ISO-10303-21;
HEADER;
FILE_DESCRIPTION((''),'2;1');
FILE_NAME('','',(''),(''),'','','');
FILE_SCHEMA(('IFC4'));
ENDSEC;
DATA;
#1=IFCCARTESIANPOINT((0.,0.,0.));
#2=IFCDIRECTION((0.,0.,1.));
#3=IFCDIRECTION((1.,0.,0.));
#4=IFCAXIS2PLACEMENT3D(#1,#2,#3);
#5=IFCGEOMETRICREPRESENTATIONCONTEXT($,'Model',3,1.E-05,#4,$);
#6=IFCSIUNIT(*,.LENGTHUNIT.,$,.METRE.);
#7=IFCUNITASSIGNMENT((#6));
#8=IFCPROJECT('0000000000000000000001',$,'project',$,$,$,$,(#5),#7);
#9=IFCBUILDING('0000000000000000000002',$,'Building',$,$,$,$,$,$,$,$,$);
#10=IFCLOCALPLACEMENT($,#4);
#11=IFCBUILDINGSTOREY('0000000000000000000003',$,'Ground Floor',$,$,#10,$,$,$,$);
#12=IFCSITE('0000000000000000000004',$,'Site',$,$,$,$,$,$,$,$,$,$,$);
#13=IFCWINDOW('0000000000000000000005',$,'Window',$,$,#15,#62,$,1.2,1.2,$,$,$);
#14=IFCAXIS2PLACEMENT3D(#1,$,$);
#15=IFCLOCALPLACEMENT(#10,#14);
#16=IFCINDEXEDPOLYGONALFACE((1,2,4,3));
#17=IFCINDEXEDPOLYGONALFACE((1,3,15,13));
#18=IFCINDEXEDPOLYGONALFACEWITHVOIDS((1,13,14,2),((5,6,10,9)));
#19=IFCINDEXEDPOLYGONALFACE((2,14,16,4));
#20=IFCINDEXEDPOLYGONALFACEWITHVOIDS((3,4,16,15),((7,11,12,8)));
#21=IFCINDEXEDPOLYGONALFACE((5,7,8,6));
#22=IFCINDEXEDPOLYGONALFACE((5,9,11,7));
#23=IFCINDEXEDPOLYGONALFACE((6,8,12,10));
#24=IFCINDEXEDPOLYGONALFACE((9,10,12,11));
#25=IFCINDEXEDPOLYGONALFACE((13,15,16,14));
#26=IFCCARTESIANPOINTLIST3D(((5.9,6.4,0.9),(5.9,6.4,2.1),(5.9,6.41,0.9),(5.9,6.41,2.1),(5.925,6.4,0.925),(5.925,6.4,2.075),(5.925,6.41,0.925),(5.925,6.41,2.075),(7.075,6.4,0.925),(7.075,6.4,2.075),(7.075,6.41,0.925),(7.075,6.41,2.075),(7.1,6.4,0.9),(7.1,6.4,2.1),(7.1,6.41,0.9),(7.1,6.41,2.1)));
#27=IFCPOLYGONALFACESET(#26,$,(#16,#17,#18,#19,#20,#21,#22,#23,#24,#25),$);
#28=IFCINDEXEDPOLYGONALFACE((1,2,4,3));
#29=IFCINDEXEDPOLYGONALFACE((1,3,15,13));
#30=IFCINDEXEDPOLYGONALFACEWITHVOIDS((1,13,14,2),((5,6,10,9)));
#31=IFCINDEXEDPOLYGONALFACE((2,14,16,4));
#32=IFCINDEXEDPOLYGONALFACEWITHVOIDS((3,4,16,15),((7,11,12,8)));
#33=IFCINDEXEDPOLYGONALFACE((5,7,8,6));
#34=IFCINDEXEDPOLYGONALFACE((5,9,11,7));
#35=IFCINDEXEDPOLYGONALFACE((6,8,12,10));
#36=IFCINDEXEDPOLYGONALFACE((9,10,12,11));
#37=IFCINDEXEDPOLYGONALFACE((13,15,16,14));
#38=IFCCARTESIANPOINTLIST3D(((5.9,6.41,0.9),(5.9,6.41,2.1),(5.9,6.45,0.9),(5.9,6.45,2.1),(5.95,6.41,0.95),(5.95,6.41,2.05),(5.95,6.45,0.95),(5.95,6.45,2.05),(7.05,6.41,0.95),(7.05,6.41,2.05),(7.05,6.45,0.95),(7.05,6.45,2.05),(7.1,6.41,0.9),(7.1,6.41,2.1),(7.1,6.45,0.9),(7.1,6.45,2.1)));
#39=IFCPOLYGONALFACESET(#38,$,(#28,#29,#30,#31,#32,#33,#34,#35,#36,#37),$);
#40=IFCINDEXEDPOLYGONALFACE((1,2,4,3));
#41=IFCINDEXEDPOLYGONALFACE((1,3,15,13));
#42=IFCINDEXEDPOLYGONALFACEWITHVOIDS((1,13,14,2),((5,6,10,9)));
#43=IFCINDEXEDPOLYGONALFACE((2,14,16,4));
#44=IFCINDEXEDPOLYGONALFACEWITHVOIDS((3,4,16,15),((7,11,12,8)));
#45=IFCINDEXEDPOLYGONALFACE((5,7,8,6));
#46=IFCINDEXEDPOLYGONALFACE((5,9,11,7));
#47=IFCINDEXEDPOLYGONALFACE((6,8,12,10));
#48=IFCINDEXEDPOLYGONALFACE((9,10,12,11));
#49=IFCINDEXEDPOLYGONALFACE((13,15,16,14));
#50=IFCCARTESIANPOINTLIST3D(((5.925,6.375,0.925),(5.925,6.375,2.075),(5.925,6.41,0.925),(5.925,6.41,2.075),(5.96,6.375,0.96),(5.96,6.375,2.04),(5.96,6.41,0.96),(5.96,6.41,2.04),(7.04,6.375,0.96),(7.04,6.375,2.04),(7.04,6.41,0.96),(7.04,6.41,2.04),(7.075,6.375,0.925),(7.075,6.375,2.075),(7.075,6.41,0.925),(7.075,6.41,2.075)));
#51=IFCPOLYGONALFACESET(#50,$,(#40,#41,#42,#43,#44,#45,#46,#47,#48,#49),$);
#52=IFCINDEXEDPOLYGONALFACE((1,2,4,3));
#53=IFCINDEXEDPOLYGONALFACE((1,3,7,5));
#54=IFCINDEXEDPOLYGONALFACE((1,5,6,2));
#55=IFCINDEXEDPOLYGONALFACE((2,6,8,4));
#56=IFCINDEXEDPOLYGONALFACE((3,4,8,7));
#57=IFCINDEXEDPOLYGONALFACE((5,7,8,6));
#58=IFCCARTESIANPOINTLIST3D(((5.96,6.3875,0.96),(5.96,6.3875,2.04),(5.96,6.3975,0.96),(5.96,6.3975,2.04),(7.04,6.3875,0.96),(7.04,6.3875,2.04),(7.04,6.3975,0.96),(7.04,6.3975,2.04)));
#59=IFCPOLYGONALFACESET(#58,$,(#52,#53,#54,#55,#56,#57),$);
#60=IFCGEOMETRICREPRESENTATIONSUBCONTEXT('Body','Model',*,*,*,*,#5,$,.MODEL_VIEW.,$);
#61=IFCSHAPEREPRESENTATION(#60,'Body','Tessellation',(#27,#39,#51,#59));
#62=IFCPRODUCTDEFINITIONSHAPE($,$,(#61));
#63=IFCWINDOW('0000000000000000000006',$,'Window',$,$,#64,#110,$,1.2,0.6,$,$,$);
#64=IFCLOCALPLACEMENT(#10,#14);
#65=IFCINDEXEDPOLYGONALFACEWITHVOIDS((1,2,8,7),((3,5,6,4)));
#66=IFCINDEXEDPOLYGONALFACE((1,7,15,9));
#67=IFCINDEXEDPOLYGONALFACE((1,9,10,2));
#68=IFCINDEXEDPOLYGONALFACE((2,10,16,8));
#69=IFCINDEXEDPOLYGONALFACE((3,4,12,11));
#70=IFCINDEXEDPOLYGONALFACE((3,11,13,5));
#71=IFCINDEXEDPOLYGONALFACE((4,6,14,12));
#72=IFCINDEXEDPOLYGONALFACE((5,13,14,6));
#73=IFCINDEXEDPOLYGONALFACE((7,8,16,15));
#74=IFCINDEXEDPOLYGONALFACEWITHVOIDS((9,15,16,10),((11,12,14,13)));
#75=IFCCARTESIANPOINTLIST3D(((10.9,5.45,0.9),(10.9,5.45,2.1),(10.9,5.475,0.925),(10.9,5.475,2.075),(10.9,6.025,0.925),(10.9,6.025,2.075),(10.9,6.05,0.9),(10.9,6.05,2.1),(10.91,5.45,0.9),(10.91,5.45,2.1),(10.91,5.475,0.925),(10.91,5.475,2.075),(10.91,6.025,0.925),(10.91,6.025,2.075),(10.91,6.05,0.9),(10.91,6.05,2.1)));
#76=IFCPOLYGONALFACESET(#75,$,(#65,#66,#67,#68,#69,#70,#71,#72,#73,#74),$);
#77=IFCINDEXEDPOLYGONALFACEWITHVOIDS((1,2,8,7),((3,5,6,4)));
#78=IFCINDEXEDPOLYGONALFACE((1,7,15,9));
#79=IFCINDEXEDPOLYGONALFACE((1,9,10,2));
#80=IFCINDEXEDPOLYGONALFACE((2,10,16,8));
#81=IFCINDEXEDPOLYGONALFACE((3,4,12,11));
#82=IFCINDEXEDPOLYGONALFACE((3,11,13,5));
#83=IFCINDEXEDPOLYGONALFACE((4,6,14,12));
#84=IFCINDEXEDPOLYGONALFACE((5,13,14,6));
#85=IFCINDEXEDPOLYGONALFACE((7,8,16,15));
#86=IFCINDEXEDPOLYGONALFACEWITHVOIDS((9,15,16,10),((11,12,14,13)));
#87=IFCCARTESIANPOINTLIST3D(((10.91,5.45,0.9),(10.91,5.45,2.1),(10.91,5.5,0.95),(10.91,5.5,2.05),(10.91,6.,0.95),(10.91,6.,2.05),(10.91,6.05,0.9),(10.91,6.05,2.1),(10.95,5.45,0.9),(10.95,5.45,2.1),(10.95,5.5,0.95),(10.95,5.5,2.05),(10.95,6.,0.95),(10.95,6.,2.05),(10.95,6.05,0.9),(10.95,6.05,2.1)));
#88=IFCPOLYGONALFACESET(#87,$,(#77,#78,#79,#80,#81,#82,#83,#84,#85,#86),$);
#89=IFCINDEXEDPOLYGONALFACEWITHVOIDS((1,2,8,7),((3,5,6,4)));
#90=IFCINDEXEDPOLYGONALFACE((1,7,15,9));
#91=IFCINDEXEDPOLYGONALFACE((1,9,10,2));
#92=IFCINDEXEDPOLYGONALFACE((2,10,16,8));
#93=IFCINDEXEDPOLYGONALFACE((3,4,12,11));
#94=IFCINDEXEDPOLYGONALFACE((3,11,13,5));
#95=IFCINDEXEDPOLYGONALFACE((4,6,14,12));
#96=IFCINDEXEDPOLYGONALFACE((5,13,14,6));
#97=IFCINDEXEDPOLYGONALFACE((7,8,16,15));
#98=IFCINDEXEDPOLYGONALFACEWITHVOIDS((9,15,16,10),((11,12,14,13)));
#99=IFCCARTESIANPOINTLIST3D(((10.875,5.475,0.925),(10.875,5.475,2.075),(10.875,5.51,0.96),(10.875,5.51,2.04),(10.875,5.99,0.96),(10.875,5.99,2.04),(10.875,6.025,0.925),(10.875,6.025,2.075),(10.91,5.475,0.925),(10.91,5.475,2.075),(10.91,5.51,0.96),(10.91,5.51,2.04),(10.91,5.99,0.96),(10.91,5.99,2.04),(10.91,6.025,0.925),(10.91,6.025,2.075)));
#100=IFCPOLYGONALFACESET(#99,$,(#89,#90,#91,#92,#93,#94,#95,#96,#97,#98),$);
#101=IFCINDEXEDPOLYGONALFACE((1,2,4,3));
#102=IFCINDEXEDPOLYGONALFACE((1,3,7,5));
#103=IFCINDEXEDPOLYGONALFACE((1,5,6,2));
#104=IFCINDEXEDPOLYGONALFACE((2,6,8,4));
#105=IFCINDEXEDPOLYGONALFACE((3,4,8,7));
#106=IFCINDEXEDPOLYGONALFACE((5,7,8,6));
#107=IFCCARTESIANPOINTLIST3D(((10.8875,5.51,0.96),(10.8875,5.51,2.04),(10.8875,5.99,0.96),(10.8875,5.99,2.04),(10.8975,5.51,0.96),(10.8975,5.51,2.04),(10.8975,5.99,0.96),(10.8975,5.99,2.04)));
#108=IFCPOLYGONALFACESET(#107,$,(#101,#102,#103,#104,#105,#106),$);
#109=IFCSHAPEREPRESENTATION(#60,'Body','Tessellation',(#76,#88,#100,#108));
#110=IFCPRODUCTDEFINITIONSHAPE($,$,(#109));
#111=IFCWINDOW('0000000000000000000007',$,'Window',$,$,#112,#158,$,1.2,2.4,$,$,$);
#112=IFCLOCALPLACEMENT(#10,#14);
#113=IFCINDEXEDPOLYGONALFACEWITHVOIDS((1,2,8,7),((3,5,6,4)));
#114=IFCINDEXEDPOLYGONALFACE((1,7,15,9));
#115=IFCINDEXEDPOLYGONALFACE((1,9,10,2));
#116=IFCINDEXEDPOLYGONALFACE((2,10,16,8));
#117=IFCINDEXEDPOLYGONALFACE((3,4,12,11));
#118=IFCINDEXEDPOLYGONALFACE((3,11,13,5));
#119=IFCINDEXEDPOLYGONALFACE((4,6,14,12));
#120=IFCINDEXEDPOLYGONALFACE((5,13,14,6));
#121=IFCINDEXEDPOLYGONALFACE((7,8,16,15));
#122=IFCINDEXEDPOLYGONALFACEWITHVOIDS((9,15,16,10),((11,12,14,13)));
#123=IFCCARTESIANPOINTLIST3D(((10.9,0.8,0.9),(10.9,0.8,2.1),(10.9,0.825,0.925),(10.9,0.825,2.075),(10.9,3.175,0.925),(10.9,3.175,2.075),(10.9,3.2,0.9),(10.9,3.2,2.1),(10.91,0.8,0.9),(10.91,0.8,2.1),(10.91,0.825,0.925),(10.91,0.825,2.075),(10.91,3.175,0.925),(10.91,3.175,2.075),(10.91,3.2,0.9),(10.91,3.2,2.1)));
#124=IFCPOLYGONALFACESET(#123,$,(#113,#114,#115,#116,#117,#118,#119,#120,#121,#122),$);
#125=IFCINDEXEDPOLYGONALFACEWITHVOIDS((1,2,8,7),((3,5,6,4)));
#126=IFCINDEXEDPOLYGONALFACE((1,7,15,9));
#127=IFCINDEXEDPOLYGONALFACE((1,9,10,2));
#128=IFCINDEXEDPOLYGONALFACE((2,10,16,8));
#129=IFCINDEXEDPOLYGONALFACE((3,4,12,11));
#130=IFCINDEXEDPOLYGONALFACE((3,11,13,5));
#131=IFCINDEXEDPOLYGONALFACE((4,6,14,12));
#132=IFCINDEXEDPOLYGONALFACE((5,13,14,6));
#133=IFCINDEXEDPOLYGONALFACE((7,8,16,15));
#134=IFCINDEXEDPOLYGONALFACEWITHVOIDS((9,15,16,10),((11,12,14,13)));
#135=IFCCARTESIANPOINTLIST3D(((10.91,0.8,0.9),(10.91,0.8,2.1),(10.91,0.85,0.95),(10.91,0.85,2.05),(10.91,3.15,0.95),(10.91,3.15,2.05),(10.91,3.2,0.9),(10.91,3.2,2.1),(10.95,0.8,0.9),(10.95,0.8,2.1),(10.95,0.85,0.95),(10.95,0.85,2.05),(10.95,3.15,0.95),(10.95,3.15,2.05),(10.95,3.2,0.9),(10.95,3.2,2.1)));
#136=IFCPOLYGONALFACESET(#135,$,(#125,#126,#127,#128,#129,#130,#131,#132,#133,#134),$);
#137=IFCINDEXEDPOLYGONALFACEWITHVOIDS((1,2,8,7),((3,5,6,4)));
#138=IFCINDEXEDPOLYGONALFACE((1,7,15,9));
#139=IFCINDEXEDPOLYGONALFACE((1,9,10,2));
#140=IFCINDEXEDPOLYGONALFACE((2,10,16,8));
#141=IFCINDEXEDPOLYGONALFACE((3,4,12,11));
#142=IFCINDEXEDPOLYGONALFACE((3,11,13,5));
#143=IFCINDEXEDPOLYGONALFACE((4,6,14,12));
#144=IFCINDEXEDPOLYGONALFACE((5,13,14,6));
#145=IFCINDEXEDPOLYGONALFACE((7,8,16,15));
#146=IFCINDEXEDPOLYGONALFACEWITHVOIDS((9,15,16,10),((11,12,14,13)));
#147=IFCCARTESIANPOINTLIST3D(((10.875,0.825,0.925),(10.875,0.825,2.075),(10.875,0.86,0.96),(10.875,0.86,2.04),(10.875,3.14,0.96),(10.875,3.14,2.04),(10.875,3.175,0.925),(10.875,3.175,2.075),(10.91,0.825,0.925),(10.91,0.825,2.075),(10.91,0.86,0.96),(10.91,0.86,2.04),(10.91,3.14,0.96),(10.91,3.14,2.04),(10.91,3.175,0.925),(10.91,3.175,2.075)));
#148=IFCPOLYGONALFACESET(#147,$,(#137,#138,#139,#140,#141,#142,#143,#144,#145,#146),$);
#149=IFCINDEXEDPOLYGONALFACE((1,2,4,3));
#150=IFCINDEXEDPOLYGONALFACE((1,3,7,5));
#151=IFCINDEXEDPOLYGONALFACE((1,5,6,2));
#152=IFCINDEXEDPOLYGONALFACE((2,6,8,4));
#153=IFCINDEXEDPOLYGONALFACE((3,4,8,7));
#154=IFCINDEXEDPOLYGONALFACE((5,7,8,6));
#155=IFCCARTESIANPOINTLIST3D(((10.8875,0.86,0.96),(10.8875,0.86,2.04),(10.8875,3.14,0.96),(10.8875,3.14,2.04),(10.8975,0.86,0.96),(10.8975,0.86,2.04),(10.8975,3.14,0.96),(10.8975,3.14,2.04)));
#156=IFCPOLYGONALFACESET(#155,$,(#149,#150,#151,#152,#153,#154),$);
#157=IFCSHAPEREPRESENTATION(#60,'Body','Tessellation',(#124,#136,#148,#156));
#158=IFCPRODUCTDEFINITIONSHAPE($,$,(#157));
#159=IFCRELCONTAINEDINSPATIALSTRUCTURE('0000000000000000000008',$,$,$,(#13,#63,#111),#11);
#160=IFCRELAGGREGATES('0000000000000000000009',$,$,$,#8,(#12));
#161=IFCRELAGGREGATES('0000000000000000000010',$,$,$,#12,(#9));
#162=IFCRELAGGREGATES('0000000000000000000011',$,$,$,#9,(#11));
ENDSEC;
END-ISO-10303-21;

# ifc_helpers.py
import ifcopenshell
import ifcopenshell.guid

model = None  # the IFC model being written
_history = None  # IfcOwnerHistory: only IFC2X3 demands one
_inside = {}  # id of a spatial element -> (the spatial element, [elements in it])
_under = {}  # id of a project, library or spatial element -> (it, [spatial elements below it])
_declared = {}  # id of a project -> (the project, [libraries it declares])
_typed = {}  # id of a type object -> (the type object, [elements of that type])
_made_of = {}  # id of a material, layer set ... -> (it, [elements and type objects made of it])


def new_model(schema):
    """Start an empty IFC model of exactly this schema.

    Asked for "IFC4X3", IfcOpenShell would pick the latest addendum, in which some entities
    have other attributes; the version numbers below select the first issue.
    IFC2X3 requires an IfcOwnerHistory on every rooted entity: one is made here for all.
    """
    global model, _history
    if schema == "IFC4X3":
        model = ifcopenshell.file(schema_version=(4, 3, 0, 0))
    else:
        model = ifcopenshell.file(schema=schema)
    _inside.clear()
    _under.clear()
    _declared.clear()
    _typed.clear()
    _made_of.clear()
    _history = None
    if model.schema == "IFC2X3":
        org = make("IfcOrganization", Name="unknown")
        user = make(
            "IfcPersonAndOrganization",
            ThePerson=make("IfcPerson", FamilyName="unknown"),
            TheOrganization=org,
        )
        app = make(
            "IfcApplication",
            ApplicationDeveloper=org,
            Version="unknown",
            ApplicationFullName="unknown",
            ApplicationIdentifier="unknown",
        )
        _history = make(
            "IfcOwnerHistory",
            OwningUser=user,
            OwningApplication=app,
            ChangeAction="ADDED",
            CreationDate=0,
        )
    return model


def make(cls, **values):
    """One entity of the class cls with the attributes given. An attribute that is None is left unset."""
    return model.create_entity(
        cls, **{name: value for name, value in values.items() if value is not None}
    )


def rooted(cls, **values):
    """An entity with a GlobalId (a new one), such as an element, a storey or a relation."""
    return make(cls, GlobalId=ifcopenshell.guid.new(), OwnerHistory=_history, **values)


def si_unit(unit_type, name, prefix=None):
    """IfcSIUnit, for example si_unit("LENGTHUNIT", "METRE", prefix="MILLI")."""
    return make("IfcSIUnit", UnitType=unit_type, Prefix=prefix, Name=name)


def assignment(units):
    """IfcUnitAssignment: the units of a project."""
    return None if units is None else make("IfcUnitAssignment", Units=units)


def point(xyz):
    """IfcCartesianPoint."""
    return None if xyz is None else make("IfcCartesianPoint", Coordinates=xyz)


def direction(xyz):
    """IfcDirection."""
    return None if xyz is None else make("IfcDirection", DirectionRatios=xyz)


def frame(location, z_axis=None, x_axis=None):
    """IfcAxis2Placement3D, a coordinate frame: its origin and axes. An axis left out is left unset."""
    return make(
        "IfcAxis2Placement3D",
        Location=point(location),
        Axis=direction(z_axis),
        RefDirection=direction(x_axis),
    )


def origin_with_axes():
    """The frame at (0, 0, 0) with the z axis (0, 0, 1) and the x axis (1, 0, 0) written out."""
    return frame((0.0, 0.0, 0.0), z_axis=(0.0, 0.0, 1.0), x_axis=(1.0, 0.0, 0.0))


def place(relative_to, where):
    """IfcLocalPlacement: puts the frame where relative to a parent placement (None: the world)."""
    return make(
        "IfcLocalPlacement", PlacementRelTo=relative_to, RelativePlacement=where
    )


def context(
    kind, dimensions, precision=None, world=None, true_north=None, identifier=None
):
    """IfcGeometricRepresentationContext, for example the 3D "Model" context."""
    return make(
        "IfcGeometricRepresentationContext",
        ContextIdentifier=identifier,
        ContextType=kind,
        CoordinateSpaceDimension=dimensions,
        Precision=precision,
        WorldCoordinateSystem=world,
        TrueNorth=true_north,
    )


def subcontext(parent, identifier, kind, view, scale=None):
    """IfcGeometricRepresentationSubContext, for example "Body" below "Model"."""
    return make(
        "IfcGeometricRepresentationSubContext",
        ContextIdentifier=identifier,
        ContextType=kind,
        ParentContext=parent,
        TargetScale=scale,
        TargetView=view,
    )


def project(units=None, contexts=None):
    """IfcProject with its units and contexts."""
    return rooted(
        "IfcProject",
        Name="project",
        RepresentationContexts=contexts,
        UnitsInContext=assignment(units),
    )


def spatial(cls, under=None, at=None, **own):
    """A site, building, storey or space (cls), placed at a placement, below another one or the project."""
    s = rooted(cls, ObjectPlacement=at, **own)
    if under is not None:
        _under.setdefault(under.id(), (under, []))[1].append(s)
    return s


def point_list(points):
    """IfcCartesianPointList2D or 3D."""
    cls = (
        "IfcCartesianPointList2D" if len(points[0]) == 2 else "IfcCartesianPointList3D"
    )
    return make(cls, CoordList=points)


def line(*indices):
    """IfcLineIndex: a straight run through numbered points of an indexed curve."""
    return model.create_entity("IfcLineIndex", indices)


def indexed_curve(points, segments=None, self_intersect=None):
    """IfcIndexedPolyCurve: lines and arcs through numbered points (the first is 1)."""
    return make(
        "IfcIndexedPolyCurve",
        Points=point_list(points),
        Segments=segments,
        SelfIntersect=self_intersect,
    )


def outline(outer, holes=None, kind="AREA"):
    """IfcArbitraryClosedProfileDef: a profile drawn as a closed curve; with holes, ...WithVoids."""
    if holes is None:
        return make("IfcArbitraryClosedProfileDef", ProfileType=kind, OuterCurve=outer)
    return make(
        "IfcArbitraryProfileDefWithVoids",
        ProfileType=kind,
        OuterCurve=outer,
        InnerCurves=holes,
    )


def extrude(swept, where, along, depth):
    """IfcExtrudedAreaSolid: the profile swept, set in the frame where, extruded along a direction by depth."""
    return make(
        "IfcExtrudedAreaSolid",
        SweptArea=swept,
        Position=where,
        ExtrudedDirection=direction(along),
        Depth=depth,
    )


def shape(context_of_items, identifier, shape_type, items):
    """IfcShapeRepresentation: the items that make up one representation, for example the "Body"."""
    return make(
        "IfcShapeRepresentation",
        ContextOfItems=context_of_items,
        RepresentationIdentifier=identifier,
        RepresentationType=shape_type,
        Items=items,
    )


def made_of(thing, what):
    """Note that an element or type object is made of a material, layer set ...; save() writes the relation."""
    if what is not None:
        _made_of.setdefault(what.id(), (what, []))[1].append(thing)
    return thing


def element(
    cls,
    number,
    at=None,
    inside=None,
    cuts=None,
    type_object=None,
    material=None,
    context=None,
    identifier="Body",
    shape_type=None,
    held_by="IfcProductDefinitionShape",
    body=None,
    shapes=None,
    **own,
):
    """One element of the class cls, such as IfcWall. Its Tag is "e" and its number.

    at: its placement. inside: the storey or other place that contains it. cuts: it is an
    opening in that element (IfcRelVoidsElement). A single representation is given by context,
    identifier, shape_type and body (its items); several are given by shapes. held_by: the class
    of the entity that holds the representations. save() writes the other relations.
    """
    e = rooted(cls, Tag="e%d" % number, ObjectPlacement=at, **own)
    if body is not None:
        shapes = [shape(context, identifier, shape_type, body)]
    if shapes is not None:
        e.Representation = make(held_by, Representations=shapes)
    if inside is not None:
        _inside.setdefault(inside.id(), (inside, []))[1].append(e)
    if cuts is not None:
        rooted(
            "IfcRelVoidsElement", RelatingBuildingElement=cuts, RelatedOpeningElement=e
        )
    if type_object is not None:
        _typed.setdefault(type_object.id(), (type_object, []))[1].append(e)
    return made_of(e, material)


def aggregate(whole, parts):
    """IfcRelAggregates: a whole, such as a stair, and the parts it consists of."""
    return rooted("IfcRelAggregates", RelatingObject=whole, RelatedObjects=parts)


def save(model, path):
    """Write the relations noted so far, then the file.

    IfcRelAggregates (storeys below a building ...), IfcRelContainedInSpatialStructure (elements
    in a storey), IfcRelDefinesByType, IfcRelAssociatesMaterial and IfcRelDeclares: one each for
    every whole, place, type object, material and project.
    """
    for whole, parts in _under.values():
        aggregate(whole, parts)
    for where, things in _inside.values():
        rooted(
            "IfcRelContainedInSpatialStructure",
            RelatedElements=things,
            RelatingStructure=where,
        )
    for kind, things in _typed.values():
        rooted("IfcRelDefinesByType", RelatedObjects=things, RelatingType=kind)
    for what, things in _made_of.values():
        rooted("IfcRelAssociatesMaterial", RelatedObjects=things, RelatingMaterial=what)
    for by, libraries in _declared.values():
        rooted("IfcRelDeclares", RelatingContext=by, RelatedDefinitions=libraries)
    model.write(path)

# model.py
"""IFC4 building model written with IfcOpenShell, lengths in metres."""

from ifc_helpers import new_model, si_unit, frame, origin_with_axes, place, context, subcontext, project, spatial, line, indexed_curve, outline, extrude, element, save


model = new_model("IFC4")

# Units and contexts
model_context = context("Model", 3, precision=1e-05, world=origin_with_axes())
body_context = subcontext(model_context, "Body", "Model", "MODEL_VIEW")
ifc_project = project(units=[si_unit("LENGTHUNIT", "METRE")], contexts=[model_context])

# Site, building, storey
site = spatial("IfcSite", under=ifc_project, Name="Site")
building = spatial("IfcBuilding", under=site, Name="Building")
storey_placement = place(None, origin_with_axes())
storey = spatial("IfcBuildingStorey", under=building, at=storey_placement, Name="Ground Floor")

# Windows
window_1_placement = place(storey_placement, frame((7.1, 6.5, 0.9), z_axis=(0.0, 0.0, 1.0), x_axis=(-1.0, 0.0, 0.0)))
element("IfcWindow", 1, at=window_1_placement, inside=storey, Name="Window", OverallHeight=1.2, OverallWidth=1.2, context=body_context, shape_type="SweptSolid", body=[
    extrude(outline(indexed_curve([(0.0, 0.0), (1.2, 0.0), (1.2, 1.2), (0.0, 1.2)], segments=[line(1, 2, 3, 4, 1)]), holes=[indexed_curve([(0.025, 0.025), (1.175, 0.025), (1.175, 1.175), (0.025, 1.175)], segments=[line(1, 2, 3, 4, 1)])]), frame((0.0, 0.09, 0.0), z_axis=(0.0, -1.0, 0.0), x_axis=(1.0, 0.0, 0.0)), (0.0, 0.0, -1.0), 0.01),
    extrude(outline(indexed_curve([(0.0, 0.0), (1.2, 0.0), (1.2, 1.2), (0.0, 1.2)], segments=[line(1, 2, 3, 4, 1)]), holes=[indexed_curve([(0.05, 0.05), (1.15, 0.05), (1.15, 1.15), (0.05, 1.15)], segments=[line(1, 2, 3, 4, 1)])]), frame((0.0, 0.05, 0.0), z_axis=(0.0, -1.0, 0.0), x_axis=(1.0, 0.0, 0.0)), (0.0, 0.0, -1.0), 0.04),
    extrude(outline(indexed_curve([(0.0, 0.0), (1.15, 0.0), (1.15, 1.15), (0.0, 1.15)], segments=[line(1, 2, 3, 4, 1)]), holes=[indexed_curve([(0.035, 0.035), (1.115, 0.035), (1.115, 1.115), (0.035, 1.115)], segments=[line(1, 2, 3, 4, 1)])]), frame((0.025, 0.09, 0.025), z_axis=(0.0, -1.0, 0.0), x_axis=(1.0, 0.0, 0.0)), (0.0, 0.0, -1.0), 0.035),
    extrude(outline(indexed_curve([(0.035, 0.035), (1.115, 0.035), (1.115, 1.115), (0.035, 1.115)], segments=[line(1, 2, 3, 4, 1)])), frame((0.025, 0.1025, 0.025), z_axis=(0.0, -1.0, 0.0), x_axis=(1.0, 0.0, 0.0)), (0.0, 0.0, -1.0), 0.01),
])
window_2_placement = place(storey_placement, frame((11.0, 5.45, 0.9), z_axis=(0.0, 0.0, 1.0), x_axis=(0.0, 1.0, 0.0)))
element("IfcWindow", 2, at=window_2_placement, inside=storey, Name="Window", OverallHeight=1.2, OverallWidth=0.6, context=body_context, shape_type="SweptSolid", body=[
    extrude(outline(indexed_curve([(0.0, 0.0), (0.6, 0.0), (0.6, 1.2), (0.0, 1.2)], segments=[line(1, 2, 3, 4, 1)]), holes=[indexed_curve([(0.025, 0.025), (0.575, 0.025), (0.575, 1.175), (0.025, 1.175)], segments=[line(1, 2, 3, 4, 1)])]), frame((0.0, 0.09, 0.0), z_axis=(0.0, -1.0, 0.0), x_axis=(1.0, 0.0, 0.0)), (0.0, 0.0, -1.0), 0.01),
    extrude(outline(indexed_curve([(0.0, 0.0), (0.6, 0.0), (0.6, 1.2), (0.0, 1.2)], segments=[line(1, 2, 3, 4, 1)]), holes=[indexed_curve([(0.05, 0.05), (0.55, 0.05), (0.55, 1.15), (0.05, 1.15)], segments=[line(1, 2, 3, 4, 1)])]), frame((0.0, 0.05, 0.0), z_axis=(0.0, -1.0, 0.0), x_axis=(1.0, 0.0, 0.0)), (0.0, 0.0, -1.0), 0.04),
    extrude(outline(indexed_curve([(0.0, 0.0), (0.55, 0.0), (0.55, 1.15), (0.0, 1.15)], segments=[line(1, 2, 3, 4, 1)]), holes=[indexed_curve([(0.035, 0.035), (0.515, 0.035), (0.515, 1.115), (0.035, 1.115)], segments=[line(1, 2, 3, 4, 1)])]), frame((0.025, 0.09, 0.025), z_axis=(0.0, -1.0, 0.0), x_axis=(1.0, 0.0, 0.0)), (0.0, 0.0, -1.0), 0.035),
    extrude(outline(indexed_curve([(0.035, 0.035), (0.515, 0.035), (0.515, 1.115), (0.035, 1.115)], segments=[line(1, 2, 3, 4, 1)])), frame((0.025, 0.1025, 0.025), z_axis=(0.0, -1.0, 0.0), x_axis=(1.0, 0.0, 0.0)), (0.0, 0.0, -1.0), 0.01),
])
window_3_placement = place(storey_placement, frame((11.0, 0.8, 0.9), z_axis=(0.0, 0.0, 1.0), x_axis=(0.0, 1.0, 0.0)))
element("IfcWindow", 3, at=window_3_placement, inside=storey, Name="Window", OverallHeight=1.2, OverallWidth=2.4, context=body_context, shape_type="SweptSolid", body=[
    extrude(outline(indexed_curve([(0.0, 0.0), (2.4, 0.0), (2.4, 1.2), (0.0, 1.2)], segments=[line(1, 2, 3, 4, 1)]), holes=[indexed_curve([(0.025, 0.025), (2.375, 0.025), (2.375, 1.175), (0.025, 1.175)], segments=[line(1, 2, 3, 4, 1)])]), frame((0.0, 0.09, 0.0), z_axis=(0.0, -1.0, 0.0), x_axis=(1.0, 0.0, 0.0)), (0.0, 0.0, -1.0), 0.01),
    extrude(outline(indexed_curve([(0.0, 0.0), (2.4, 0.0), (2.4, 1.2), (0.0, 1.2)], segments=[line(1, 2, 3, 4, 1)]), holes=[indexed_curve([(0.05, 0.05), (2.35, 0.05), (2.35, 1.15), (0.05, 1.15)], segments=[line(1, 2, 3, 4, 1)])]), frame((0.0, 0.05, 0.0), z_axis=(0.0, -1.0, 0.0), x_axis=(1.0, 0.0, 0.0)), (0.0, 0.0, -1.0), 0.04),
    extrude(outline(indexed_curve([(0.0, 0.0), (2.35, 0.0), (2.35, 1.15), (0.0, 1.15)], segments=[line(1, 2, 3, 4, 1)]), holes=[indexed_curve([(0.035, 0.035), (2.315, 0.035), (2.315, 1.115), (0.035, 1.115)], segments=[line(1, 2, 3, 4, 1)])]), frame((0.025, 0.09, 0.025), z_axis=(0.0, -1.0, 0.0), x_axis=(1.0, 0.0, 0.0)), (0.0, 0.0, -1.0), 0.035),
    extrude(outline(indexed_curve([(0.035, 0.035), (2.315, 0.035), (2.315, 1.115), (0.035, 1.115)], segments=[line(1, 2, 3, 4, 1)])), frame((0.025, 0.1025, 0.025), z_axis=(0.0, -1.0, 0.0), x_axis=(1.0, 0.0, 0.0)), (0.0, 0.0, -1.0), 0.01),
])

save(model, "model.ifc")
